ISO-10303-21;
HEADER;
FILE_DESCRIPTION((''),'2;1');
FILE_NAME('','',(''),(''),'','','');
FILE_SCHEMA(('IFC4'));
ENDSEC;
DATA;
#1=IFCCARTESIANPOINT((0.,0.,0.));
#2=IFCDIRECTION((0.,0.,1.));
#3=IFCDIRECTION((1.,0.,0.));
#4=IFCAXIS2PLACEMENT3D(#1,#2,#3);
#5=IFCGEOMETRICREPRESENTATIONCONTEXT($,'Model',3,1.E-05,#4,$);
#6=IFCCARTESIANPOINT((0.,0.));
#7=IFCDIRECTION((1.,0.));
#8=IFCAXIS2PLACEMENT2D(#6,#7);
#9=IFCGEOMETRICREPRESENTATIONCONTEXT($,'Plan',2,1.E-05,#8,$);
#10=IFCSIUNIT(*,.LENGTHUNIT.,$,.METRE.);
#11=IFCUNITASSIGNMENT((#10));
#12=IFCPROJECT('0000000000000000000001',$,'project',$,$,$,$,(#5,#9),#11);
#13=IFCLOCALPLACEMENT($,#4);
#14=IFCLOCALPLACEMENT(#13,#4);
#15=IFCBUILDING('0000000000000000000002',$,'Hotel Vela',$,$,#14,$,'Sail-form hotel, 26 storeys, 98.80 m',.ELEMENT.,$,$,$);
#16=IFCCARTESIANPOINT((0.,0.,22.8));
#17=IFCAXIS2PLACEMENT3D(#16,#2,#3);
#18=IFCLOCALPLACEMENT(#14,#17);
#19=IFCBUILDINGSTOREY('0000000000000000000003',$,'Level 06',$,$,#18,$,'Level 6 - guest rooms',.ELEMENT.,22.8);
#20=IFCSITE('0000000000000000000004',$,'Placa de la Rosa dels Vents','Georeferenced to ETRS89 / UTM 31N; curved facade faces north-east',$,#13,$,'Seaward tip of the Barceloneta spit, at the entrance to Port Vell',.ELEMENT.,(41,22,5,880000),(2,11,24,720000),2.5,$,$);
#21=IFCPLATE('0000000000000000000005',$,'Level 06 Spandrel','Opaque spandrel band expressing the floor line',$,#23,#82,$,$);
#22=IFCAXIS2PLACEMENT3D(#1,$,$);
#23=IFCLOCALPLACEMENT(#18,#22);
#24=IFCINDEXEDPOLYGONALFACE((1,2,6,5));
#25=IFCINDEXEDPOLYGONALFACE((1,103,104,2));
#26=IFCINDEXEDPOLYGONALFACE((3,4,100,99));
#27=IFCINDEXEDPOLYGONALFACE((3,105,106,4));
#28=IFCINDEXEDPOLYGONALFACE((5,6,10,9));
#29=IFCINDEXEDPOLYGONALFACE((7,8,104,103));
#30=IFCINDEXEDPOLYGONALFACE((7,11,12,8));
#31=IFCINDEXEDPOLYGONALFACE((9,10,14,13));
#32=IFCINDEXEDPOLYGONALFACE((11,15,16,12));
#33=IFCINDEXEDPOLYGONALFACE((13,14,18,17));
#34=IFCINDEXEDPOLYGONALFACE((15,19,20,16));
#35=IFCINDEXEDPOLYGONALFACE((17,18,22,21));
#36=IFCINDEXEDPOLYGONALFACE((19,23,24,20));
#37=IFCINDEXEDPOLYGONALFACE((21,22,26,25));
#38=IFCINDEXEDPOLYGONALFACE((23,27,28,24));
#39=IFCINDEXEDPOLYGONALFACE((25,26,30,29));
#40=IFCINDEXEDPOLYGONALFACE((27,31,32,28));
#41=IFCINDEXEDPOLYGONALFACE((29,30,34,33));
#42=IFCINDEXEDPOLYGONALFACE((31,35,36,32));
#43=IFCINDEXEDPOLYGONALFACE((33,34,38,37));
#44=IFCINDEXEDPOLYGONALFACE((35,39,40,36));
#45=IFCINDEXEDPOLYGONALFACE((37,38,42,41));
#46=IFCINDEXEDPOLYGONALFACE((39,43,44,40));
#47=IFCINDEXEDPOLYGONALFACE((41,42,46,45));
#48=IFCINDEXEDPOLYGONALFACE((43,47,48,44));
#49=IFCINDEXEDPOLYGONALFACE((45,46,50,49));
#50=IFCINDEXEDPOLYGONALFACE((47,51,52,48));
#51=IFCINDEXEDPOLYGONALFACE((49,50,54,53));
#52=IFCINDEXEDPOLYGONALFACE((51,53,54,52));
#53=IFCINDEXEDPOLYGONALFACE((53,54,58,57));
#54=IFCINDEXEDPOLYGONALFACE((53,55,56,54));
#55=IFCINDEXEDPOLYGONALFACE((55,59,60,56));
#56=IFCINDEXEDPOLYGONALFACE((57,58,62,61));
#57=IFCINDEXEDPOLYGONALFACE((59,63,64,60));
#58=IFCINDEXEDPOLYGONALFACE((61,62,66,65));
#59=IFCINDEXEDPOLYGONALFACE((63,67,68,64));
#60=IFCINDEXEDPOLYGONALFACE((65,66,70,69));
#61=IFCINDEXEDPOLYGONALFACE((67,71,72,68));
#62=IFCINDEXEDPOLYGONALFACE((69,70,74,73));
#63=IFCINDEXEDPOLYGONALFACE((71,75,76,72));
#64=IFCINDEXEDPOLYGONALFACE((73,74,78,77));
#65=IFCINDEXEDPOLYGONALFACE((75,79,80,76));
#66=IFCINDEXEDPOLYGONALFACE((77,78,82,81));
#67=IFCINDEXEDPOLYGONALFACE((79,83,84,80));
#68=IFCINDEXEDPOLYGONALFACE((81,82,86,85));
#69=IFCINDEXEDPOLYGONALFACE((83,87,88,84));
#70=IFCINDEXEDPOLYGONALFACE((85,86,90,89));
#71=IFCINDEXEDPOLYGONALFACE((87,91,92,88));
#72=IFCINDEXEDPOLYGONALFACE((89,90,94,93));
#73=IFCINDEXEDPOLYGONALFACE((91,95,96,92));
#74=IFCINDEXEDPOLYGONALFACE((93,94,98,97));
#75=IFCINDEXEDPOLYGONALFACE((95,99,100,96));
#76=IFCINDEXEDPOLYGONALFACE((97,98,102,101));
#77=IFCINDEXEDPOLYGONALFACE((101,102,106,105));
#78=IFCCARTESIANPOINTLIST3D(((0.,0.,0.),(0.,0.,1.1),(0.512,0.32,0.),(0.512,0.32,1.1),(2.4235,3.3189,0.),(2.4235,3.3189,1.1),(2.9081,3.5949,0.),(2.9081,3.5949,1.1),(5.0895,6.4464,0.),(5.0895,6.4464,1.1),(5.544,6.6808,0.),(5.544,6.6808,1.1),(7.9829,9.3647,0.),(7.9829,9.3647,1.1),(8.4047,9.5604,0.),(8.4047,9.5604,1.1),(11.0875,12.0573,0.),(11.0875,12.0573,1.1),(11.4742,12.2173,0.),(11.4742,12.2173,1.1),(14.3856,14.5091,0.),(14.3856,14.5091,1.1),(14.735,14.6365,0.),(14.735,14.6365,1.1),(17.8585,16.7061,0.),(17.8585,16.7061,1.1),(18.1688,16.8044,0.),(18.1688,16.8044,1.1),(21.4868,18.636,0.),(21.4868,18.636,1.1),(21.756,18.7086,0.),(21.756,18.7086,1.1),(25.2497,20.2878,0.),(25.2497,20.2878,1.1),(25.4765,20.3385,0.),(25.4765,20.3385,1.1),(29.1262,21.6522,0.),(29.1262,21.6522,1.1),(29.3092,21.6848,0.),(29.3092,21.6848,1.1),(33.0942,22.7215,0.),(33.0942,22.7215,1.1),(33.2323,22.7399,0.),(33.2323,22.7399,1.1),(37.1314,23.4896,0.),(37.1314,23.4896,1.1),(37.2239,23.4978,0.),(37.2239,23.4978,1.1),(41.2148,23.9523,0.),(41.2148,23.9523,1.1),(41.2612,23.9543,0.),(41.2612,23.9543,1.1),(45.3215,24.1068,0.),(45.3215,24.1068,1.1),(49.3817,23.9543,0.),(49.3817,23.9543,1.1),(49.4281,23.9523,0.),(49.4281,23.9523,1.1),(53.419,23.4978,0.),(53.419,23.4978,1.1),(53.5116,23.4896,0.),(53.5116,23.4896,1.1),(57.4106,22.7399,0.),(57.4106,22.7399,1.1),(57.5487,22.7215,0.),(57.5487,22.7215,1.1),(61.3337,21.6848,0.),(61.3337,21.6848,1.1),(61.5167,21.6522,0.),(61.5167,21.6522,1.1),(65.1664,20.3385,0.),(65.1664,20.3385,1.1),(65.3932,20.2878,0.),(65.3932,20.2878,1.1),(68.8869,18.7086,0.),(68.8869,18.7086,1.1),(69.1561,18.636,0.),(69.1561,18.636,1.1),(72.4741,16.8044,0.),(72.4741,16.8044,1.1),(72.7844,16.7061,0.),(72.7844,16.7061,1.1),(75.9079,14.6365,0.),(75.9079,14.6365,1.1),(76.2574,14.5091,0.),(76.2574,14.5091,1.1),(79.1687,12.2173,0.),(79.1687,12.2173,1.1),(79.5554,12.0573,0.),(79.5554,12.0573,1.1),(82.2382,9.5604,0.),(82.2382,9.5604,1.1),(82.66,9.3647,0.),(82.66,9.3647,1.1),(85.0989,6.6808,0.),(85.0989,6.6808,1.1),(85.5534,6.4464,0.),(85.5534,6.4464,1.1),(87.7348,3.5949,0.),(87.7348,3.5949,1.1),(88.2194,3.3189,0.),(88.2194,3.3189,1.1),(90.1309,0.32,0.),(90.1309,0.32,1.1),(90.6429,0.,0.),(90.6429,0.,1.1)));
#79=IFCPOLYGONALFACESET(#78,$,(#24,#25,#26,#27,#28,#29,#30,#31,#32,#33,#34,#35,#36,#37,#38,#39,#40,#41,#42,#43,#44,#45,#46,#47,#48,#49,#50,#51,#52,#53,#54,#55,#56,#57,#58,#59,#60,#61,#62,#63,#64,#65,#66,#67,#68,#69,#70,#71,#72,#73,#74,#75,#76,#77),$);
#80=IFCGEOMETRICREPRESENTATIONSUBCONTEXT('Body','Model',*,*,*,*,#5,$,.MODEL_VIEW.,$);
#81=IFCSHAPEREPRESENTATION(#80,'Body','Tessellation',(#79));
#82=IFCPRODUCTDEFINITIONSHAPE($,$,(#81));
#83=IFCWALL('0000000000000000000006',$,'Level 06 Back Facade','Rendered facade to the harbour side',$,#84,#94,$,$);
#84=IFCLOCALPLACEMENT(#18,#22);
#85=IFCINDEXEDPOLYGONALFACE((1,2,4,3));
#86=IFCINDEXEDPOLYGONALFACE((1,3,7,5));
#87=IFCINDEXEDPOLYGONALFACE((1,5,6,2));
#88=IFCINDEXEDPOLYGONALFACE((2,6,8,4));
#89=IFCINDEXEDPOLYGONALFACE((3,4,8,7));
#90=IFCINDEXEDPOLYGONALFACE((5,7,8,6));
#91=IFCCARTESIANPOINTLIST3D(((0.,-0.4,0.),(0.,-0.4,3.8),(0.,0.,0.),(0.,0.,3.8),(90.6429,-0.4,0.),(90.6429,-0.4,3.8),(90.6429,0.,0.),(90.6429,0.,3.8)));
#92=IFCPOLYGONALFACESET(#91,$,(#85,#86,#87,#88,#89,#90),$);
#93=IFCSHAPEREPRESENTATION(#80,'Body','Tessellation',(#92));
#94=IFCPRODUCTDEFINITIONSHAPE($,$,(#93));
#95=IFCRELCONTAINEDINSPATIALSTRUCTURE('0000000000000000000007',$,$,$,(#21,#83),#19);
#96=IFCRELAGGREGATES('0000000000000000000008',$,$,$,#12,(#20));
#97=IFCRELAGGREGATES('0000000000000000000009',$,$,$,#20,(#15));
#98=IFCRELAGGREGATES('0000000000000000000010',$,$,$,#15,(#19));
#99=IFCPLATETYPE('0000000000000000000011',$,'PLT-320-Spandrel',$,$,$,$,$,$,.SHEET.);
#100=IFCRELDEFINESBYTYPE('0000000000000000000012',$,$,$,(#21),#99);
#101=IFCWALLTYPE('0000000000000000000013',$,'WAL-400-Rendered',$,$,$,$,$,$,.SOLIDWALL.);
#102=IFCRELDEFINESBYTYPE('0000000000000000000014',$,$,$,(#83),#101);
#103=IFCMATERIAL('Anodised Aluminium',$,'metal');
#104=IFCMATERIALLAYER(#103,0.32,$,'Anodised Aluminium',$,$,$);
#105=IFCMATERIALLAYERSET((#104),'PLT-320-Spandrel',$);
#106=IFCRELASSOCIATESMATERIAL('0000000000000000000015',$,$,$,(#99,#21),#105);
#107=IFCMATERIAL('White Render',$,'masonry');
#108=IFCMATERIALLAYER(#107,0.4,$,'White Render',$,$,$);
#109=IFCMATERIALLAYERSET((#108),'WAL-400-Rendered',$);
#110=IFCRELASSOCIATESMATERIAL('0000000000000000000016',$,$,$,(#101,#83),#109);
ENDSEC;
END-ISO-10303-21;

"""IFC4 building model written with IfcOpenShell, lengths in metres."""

from ifc_helpers import new_model, si_unit, frame, origin_with_axes, origin_2d_with_axis, place, context, subcontext, project, spatial, line, indexed_curve, outline, extrude, material, layer, layer_set, layer_usage, type_object, element, save


model = new_model("IFC4")

# Units and contexts
model_context = context("Model", 3, precision=1e-05, world=origin_with_axes())
plan_context = context("Plan", 2, precision=1e-05, world=origin_2d_with_axis())
body_context = subcontext(model_context, "Body", "Model", "MODEL_VIEW")
ifc_project = project(units=[si_unit("LENGTHUNIT", "METRE")], contexts=[model_context, plan_context])

# Site, building, storey
site_placement = place(None, origin_with_axes())
site = spatial("IfcSite", under=ifc_project, at=site_placement, Name="Placa de la Rosa dels Vents", Description="Georeferenced to ETRS89 / UTM 31N; curved facade faces north-east", LongName="Seaward tip of the Barceloneta spit, at the entrance to Port Vell", CompositionType="ELEMENT", RefLatitude=(41, 22, 5, 880000), RefLongitude=(2, 11, 24, 720000), RefElevation=2.5)
building_placement = place(site_placement, origin_with_axes())
building = spatial("IfcBuilding", under=site, at=building_placement, Name="Hotel Vela", LongName="Sail-form hotel, 26 storeys, 98.80 m", CompositionType="ELEMENT")
storey_placement = place(building_placement, frame((0.0, 0.0, 22.8), z_axis=(0.0, 0.0, 1.0), x_axis=(1.0, 0.0, 0.0)))
storey = spatial("IfcBuildingStorey", under=building, at=storey_placement, Name="Level 06", LongName="Level 6 - guest rooms", CompositionType="ELEMENT", Elevation=22.8)

# Plate
ifc_material_1 = material(Name="Anodised Aluminium", Category="metal")
ifc_layer_1 = layer(ifc_material_1, 0.32, Name="Anodised Aluminium")
ifc_layer_set_1 = layer_set([ifc_layer_1], Name="PLT-320-Spandrel")
ifc_layer_usage_1 = layer_usage(ifc_layer_set_1, "AXIS2", "POSITIVE", 0.0)
plate_type_1 = type_object("IfcPlateType", Name="PLT-320-Spandrel", PredefinedType="SHEET", material=ifc_layer_set_1)
plate_1_placement = place(storey_placement, origin_with_axes())
element("IfcPlate", 1, at=plate_1_placement, inside=storey, type_object=plate_type_1, material=ifc_layer_usage_1, Name="Level 06 Spandrel", Description="Opaque spandrel band expressing the floor line", context=body_context, shape_type="SweptSolid", body=[
    extrude(outline(indexed_curve([(90.6429, 0.0), (88.2194, 3.3189), (85.5534, 6.4464), (82.66, 9.3647), (79.5554, 12.0573), (76.2574, 14.5091), (72.7844, 16.7061), (69.1561, 18.636), (65.3932, 20.2878), (61.5167, 21.6522), (57.5487, 22.7215), (53.5116, 23.4896), (49.4281, 23.9523), (45.3215, 24.1068), (41.2148, 23.9523), (37.1314, 23.4896), (33.0942, 22.7215), (29.1262, 21.6522), (25.2497, 20.2878), (21.4868, 18.636), (17.8585, 16.7061), (14.3856, 14.5091), (11.0875, 12.0573), (7.9829, 9.3647), (5.0895, 6.4464), (2.4235, 3.3189), (0.0, 0.0), (90.1309, 0.32), (2.9081, 3.5949), (5.544, 6.6808), (8.4047, 9.5604), (11.4742, 12.2173), (14.735, 14.6365), (18.1688, 16.8044), (21.756, 18.7086), (25.4765, 20.3385), (29.3092, 21.6848), (33.2323, 22.7399), (37.2239, 23.4978), (41.2612, 23.9543), (45.3215, 24.1068), (49.3817, 23.9543), (53.419, 23.4978), (57.4106, 22.7399), (61.3337, 21.6848), (65.1664, 20.3385), (68.8869, 18.7086), (72.4741, 16.8044), (75.9079, 14.6365), (79.1687, 12.2173), (82.2382, 9.5604), (85.0989, 6.6808), (87.7348, 3.5949), (0.512, 0.32)], segments=[line(1, 2, 3, 4, 5, 6, 7, 8, 9, 10, 11, 12, 13, 14, 15, 16, 17, 18, 19, 20, 21, 22, 23, 24, 25, 26, 27, 28, 29, 30, 31, 32, 33, 34, 35, 36, 37, 38, 39, 40, 41, 42, 43, 44, 45, 46, 47, 48, 49, 50, 51, 52, 53, 54, 1)])), origin_with_axes(), (0.0, 0.0, 1.0), 1.1),
])

# Wall
ifc_material_2 = material(Name="White Render", Category="masonry")
ifc_layer_2 = layer(ifc_material_2, 0.4, Name="White Render")
ifc_layer_set_2 = layer_set([ifc_layer_2], Name="WAL-400-Rendered")
ifc_layer_usage_2 = layer_usage(ifc_layer_set_2, "AXIS2", "POSITIVE", 0.0)
wall_type = type_object("IfcWallType", Name="WAL-400-Rendered", PredefinedType="SOLIDWALL", material=ifc_layer_set_2)
wall_placement = place(storey_placement, frame((0.0, -0.4, 0.0), z_axis=(0.0, 0.0, 1.0), x_axis=(1.0, 0.0, 0.0)))
element("IfcWall", 2, at=wall_placement, inside=storey, type_object=wall_type, material=ifc_layer_usage_2, Name="Level 06 Back Facade", Description="Rendered facade to the harbour side", context=body_context, shape_type="SweptSolid", body=[
    extrude(outline(indexed_curve([(0.0, 0.0), (90.6429, 0.0), (90.6429, 0.4), (0.0, 0.4)], segments=[line(1, 2, 3, 4, 1)])), origin_with_axes(), (0.0, 0.0, 1.0), 3.8),
])

save(model, "model.ifc")
